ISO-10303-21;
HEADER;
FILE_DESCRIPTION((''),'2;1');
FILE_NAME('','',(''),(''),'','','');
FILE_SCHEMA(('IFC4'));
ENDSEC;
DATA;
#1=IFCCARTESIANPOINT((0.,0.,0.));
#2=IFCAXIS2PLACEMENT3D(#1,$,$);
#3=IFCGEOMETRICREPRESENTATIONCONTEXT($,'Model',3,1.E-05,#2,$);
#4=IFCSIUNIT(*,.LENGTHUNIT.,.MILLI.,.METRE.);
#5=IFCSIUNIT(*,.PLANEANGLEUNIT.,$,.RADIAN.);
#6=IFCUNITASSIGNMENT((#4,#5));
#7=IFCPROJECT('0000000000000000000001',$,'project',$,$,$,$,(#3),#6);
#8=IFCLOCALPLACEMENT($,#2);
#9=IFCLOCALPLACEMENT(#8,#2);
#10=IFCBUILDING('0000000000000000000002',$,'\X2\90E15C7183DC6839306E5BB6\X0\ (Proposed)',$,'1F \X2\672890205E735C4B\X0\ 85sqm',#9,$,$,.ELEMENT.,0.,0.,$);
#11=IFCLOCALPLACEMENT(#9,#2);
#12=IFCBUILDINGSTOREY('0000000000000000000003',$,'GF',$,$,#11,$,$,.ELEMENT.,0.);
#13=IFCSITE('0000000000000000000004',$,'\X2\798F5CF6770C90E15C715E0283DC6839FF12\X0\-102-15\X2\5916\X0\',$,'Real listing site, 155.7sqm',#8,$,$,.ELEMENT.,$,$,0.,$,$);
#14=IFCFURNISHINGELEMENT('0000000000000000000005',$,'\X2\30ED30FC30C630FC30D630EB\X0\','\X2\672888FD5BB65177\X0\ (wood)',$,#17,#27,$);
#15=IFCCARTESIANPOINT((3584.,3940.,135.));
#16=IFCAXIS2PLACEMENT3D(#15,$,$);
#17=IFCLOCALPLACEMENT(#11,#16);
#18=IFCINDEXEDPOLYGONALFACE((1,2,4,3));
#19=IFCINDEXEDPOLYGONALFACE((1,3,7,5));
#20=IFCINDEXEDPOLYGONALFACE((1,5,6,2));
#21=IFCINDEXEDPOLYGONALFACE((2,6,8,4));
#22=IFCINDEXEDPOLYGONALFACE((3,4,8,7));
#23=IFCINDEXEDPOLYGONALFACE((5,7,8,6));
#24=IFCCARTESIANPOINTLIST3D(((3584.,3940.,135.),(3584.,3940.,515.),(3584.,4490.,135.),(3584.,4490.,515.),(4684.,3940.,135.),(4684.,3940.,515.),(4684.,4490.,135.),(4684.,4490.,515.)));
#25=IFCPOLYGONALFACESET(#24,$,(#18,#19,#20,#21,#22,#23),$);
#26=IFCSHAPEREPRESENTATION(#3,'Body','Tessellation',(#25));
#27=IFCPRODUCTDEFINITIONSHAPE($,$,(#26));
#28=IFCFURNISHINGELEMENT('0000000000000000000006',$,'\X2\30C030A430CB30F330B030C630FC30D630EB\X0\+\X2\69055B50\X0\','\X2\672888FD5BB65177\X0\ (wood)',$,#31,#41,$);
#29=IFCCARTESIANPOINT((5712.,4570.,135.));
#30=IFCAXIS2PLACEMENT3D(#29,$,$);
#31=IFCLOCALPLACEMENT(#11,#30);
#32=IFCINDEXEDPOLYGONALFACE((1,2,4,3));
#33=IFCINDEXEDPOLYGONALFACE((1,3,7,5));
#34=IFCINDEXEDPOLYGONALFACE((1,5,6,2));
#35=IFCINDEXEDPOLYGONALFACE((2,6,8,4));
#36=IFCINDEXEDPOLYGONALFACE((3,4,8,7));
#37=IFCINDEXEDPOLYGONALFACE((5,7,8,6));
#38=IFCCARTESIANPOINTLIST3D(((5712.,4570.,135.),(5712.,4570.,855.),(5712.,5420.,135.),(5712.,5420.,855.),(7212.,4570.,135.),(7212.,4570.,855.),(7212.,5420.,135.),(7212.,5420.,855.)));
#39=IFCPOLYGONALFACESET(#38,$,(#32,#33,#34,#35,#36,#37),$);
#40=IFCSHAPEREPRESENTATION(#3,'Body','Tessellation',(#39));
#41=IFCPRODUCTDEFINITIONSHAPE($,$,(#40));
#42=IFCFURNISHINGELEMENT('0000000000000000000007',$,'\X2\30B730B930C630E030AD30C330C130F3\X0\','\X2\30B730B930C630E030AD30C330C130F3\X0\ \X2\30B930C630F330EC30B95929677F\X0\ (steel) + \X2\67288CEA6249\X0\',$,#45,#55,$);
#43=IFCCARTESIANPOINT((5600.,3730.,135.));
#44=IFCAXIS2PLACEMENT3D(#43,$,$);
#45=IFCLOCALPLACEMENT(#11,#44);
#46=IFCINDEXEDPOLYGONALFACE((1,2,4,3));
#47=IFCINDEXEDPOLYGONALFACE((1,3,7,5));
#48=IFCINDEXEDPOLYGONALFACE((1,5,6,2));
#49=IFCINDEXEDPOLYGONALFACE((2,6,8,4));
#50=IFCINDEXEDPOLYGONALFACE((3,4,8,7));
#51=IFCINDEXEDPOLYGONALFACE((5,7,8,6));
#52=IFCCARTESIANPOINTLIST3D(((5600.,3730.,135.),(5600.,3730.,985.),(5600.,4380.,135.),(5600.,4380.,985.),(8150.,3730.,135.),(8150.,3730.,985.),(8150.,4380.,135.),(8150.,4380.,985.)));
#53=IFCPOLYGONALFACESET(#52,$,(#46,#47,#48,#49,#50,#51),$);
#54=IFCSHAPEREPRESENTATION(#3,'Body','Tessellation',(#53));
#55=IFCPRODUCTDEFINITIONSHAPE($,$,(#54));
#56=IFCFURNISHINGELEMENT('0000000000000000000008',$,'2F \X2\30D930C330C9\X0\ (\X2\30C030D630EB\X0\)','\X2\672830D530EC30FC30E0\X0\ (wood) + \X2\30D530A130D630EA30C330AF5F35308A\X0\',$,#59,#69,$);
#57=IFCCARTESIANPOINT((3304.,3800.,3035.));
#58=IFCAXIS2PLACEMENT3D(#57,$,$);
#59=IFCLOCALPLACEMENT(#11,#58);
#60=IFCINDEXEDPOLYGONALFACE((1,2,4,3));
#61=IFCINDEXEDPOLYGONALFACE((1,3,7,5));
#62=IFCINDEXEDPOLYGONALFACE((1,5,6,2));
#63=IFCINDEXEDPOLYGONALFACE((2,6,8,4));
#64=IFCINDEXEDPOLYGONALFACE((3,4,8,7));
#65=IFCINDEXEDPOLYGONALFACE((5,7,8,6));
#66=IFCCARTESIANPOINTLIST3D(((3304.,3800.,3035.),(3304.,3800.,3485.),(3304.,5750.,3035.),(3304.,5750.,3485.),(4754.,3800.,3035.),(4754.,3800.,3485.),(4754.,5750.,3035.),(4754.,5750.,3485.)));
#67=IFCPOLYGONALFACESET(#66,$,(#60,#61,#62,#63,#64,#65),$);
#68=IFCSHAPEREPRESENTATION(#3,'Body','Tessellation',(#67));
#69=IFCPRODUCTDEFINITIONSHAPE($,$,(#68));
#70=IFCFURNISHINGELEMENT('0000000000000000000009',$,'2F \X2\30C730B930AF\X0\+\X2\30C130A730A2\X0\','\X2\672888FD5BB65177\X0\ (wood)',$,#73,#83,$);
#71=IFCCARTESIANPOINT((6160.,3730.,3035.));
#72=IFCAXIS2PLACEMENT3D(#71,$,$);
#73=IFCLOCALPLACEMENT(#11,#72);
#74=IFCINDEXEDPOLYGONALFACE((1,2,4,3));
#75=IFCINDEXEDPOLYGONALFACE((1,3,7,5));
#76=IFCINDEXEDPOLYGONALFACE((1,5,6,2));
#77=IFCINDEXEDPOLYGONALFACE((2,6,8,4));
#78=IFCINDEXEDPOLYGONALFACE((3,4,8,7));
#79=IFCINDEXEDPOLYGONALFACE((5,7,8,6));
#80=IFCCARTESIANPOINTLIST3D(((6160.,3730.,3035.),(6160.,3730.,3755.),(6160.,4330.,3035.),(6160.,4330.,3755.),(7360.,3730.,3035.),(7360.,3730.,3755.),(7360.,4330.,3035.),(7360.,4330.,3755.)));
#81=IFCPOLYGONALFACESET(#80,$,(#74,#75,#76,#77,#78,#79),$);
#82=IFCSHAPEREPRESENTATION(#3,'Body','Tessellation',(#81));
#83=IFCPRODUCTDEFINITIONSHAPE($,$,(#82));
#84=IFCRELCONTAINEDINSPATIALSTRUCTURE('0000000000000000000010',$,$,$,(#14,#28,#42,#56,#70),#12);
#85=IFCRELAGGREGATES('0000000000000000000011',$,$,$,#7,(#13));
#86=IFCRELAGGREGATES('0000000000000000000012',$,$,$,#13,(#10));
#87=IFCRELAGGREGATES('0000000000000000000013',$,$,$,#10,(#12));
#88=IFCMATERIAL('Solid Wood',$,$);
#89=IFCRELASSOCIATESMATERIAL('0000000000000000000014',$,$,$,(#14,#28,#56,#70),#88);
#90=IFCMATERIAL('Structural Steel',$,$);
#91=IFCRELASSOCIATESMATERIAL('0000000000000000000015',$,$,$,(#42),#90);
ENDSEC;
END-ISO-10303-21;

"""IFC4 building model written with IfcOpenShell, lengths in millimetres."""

from ifc_helpers import new_model, si_unit, frame, frame_2d, origin, place, context, project, spatial, rectangle, extrude, material, element, save


model = new_model("IFC4")

# Units and contexts
model_context = context("Model", 3, precision=1e-05, world=origin())
ifc_project = project(units=[si_unit("LENGTHUNIT", "METRE", prefix="MILLI"), si_unit("PLANEANGLEUNIT", "RADIAN")], contexts=[model_context])

# Site, building, storey
site_placement = place(None, origin())
site = spatial("IfcSite", under=ifc_project, at=site_placement, Name="福島県郡山市菜根２-102-15外", ObjectType="Real listing site, 155.7sqm", CompositionType="ELEMENT", RefElevation=0.0)
building_placement = place(site_placement, origin())
building = spatial("IfcBuilding", under=site, at=building_placement, Name="郡山菜根の家 (Proposed)", ObjectType="1F 木造平屋 85sqm", CompositionType="ELEMENT", ElevationOfRefHeight=0.0, ElevationOfTerrain=0.0)
storey_placement = place(building_placement, origin())
storey = spatial("IfcBuildingStorey", under=building, at=storey_placement, Name="GF", CompositionType="ELEMENT", Elevation=0.0)

# Shared definitions
ifc_material_1 = material(Name="Solid Wood")

# Shared definitions
ifc_material_2 = material(Name="Structural Steel")

# Furnishing elements
furnishing_1_placement = place(storey_placement, frame((3584.0, 3940.0, 135.0)))
element("IfcFurnishingElement", 1, at=furnishing_1_placement, inside=storey, material=ifc_material_1, Name="ローテーブル", Description="木製家具 (wood)", context=model_context, shape_type="SweptSolid", body=[
    extrude(rectangle(XDim=1100.0, YDim=550.0, at=frame_2d((550.0, 275.0))), frame((3584.0, 3940.0, 135.0)), (0.0, 0.0, 1.0), 380.0),
])
furnishing_2_placement = place(storey_placement, frame((5712.0, 4570.0, 135.0)))
element("IfcFurnishingElement", 2, at=furnishing_2_placement, inside=storey, material=ifc_material_1, Name="ダイニングテーブル+椅子", Description="木製家具 (wood)", context=model_context, shape_type="SweptSolid", body=[
    extrude(rectangle(XDim=1500.0, YDim=850.0, at=frame_2d((750.0, 425.0))), frame((5712.0, 4570.0, 135.0)), (0.0, 0.0, 1.0), 720.0),
])
furnishing_3_placement = place(storey_placement, frame((5600.0, 3730.0, 135.0)))
element("IfcFurnishingElement", 3, at=furnishing_3_placement, inside=storey, material=ifc_material_2, Name="システムキッチン", Description="システムキッチン ステンレス天板 (steel) + 木質扉", context=model_context, shape_type="SweptSolid", body=[
    extrude(rectangle(XDim=2550.0, YDim=650.0, at=frame_2d((1275.0, 325.0))), frame((5600.0, 3730.0, 135.0)), (0.0, 0.0, 1.0), 850.0),
])
furnishing_4_placement = place(storey_placement, frame((3304.0, 3800.0, 3035.0)))
element("IfcFurnishingElement", 4, at=furnishing_4_placement, inside=storey, material=ifc_material_1, Name="2F ベッド (ダブル)", Description="木フレーム (wood) + ファブリック張り", context=model_context, shape_type="SweptSolid", body=[
    extrude(rectangle(XDim=1450.0, YDim=1950.0, at=frame_2d((725.0, 975.0))), frame((3304.0, 3800.0, 3035.0)), (0.0, 0.0, 1.0), 450.0),
])
furnishing_5_placement = place(storey_placement, frame((6160.0, 3730.0, 3035.0)))
element("IfcFurnishingElement", 5, at=furnishing_5_placement, inside=storey, material=ifc_material_1, Name="2F デスク+チェア", Description="木製家具 (wood)", context=model_context, shape_type="SweptSolid", body=[
    extrude(rectangle(XDim=1200.0, YDim=600.0, at=frame_2d((600.0, 300.0))), frame((6160.0, 3730.0, 3035.0)), (0.0, 0.0, 1.0), 720.0),
])

save(model, "model.ifc")
